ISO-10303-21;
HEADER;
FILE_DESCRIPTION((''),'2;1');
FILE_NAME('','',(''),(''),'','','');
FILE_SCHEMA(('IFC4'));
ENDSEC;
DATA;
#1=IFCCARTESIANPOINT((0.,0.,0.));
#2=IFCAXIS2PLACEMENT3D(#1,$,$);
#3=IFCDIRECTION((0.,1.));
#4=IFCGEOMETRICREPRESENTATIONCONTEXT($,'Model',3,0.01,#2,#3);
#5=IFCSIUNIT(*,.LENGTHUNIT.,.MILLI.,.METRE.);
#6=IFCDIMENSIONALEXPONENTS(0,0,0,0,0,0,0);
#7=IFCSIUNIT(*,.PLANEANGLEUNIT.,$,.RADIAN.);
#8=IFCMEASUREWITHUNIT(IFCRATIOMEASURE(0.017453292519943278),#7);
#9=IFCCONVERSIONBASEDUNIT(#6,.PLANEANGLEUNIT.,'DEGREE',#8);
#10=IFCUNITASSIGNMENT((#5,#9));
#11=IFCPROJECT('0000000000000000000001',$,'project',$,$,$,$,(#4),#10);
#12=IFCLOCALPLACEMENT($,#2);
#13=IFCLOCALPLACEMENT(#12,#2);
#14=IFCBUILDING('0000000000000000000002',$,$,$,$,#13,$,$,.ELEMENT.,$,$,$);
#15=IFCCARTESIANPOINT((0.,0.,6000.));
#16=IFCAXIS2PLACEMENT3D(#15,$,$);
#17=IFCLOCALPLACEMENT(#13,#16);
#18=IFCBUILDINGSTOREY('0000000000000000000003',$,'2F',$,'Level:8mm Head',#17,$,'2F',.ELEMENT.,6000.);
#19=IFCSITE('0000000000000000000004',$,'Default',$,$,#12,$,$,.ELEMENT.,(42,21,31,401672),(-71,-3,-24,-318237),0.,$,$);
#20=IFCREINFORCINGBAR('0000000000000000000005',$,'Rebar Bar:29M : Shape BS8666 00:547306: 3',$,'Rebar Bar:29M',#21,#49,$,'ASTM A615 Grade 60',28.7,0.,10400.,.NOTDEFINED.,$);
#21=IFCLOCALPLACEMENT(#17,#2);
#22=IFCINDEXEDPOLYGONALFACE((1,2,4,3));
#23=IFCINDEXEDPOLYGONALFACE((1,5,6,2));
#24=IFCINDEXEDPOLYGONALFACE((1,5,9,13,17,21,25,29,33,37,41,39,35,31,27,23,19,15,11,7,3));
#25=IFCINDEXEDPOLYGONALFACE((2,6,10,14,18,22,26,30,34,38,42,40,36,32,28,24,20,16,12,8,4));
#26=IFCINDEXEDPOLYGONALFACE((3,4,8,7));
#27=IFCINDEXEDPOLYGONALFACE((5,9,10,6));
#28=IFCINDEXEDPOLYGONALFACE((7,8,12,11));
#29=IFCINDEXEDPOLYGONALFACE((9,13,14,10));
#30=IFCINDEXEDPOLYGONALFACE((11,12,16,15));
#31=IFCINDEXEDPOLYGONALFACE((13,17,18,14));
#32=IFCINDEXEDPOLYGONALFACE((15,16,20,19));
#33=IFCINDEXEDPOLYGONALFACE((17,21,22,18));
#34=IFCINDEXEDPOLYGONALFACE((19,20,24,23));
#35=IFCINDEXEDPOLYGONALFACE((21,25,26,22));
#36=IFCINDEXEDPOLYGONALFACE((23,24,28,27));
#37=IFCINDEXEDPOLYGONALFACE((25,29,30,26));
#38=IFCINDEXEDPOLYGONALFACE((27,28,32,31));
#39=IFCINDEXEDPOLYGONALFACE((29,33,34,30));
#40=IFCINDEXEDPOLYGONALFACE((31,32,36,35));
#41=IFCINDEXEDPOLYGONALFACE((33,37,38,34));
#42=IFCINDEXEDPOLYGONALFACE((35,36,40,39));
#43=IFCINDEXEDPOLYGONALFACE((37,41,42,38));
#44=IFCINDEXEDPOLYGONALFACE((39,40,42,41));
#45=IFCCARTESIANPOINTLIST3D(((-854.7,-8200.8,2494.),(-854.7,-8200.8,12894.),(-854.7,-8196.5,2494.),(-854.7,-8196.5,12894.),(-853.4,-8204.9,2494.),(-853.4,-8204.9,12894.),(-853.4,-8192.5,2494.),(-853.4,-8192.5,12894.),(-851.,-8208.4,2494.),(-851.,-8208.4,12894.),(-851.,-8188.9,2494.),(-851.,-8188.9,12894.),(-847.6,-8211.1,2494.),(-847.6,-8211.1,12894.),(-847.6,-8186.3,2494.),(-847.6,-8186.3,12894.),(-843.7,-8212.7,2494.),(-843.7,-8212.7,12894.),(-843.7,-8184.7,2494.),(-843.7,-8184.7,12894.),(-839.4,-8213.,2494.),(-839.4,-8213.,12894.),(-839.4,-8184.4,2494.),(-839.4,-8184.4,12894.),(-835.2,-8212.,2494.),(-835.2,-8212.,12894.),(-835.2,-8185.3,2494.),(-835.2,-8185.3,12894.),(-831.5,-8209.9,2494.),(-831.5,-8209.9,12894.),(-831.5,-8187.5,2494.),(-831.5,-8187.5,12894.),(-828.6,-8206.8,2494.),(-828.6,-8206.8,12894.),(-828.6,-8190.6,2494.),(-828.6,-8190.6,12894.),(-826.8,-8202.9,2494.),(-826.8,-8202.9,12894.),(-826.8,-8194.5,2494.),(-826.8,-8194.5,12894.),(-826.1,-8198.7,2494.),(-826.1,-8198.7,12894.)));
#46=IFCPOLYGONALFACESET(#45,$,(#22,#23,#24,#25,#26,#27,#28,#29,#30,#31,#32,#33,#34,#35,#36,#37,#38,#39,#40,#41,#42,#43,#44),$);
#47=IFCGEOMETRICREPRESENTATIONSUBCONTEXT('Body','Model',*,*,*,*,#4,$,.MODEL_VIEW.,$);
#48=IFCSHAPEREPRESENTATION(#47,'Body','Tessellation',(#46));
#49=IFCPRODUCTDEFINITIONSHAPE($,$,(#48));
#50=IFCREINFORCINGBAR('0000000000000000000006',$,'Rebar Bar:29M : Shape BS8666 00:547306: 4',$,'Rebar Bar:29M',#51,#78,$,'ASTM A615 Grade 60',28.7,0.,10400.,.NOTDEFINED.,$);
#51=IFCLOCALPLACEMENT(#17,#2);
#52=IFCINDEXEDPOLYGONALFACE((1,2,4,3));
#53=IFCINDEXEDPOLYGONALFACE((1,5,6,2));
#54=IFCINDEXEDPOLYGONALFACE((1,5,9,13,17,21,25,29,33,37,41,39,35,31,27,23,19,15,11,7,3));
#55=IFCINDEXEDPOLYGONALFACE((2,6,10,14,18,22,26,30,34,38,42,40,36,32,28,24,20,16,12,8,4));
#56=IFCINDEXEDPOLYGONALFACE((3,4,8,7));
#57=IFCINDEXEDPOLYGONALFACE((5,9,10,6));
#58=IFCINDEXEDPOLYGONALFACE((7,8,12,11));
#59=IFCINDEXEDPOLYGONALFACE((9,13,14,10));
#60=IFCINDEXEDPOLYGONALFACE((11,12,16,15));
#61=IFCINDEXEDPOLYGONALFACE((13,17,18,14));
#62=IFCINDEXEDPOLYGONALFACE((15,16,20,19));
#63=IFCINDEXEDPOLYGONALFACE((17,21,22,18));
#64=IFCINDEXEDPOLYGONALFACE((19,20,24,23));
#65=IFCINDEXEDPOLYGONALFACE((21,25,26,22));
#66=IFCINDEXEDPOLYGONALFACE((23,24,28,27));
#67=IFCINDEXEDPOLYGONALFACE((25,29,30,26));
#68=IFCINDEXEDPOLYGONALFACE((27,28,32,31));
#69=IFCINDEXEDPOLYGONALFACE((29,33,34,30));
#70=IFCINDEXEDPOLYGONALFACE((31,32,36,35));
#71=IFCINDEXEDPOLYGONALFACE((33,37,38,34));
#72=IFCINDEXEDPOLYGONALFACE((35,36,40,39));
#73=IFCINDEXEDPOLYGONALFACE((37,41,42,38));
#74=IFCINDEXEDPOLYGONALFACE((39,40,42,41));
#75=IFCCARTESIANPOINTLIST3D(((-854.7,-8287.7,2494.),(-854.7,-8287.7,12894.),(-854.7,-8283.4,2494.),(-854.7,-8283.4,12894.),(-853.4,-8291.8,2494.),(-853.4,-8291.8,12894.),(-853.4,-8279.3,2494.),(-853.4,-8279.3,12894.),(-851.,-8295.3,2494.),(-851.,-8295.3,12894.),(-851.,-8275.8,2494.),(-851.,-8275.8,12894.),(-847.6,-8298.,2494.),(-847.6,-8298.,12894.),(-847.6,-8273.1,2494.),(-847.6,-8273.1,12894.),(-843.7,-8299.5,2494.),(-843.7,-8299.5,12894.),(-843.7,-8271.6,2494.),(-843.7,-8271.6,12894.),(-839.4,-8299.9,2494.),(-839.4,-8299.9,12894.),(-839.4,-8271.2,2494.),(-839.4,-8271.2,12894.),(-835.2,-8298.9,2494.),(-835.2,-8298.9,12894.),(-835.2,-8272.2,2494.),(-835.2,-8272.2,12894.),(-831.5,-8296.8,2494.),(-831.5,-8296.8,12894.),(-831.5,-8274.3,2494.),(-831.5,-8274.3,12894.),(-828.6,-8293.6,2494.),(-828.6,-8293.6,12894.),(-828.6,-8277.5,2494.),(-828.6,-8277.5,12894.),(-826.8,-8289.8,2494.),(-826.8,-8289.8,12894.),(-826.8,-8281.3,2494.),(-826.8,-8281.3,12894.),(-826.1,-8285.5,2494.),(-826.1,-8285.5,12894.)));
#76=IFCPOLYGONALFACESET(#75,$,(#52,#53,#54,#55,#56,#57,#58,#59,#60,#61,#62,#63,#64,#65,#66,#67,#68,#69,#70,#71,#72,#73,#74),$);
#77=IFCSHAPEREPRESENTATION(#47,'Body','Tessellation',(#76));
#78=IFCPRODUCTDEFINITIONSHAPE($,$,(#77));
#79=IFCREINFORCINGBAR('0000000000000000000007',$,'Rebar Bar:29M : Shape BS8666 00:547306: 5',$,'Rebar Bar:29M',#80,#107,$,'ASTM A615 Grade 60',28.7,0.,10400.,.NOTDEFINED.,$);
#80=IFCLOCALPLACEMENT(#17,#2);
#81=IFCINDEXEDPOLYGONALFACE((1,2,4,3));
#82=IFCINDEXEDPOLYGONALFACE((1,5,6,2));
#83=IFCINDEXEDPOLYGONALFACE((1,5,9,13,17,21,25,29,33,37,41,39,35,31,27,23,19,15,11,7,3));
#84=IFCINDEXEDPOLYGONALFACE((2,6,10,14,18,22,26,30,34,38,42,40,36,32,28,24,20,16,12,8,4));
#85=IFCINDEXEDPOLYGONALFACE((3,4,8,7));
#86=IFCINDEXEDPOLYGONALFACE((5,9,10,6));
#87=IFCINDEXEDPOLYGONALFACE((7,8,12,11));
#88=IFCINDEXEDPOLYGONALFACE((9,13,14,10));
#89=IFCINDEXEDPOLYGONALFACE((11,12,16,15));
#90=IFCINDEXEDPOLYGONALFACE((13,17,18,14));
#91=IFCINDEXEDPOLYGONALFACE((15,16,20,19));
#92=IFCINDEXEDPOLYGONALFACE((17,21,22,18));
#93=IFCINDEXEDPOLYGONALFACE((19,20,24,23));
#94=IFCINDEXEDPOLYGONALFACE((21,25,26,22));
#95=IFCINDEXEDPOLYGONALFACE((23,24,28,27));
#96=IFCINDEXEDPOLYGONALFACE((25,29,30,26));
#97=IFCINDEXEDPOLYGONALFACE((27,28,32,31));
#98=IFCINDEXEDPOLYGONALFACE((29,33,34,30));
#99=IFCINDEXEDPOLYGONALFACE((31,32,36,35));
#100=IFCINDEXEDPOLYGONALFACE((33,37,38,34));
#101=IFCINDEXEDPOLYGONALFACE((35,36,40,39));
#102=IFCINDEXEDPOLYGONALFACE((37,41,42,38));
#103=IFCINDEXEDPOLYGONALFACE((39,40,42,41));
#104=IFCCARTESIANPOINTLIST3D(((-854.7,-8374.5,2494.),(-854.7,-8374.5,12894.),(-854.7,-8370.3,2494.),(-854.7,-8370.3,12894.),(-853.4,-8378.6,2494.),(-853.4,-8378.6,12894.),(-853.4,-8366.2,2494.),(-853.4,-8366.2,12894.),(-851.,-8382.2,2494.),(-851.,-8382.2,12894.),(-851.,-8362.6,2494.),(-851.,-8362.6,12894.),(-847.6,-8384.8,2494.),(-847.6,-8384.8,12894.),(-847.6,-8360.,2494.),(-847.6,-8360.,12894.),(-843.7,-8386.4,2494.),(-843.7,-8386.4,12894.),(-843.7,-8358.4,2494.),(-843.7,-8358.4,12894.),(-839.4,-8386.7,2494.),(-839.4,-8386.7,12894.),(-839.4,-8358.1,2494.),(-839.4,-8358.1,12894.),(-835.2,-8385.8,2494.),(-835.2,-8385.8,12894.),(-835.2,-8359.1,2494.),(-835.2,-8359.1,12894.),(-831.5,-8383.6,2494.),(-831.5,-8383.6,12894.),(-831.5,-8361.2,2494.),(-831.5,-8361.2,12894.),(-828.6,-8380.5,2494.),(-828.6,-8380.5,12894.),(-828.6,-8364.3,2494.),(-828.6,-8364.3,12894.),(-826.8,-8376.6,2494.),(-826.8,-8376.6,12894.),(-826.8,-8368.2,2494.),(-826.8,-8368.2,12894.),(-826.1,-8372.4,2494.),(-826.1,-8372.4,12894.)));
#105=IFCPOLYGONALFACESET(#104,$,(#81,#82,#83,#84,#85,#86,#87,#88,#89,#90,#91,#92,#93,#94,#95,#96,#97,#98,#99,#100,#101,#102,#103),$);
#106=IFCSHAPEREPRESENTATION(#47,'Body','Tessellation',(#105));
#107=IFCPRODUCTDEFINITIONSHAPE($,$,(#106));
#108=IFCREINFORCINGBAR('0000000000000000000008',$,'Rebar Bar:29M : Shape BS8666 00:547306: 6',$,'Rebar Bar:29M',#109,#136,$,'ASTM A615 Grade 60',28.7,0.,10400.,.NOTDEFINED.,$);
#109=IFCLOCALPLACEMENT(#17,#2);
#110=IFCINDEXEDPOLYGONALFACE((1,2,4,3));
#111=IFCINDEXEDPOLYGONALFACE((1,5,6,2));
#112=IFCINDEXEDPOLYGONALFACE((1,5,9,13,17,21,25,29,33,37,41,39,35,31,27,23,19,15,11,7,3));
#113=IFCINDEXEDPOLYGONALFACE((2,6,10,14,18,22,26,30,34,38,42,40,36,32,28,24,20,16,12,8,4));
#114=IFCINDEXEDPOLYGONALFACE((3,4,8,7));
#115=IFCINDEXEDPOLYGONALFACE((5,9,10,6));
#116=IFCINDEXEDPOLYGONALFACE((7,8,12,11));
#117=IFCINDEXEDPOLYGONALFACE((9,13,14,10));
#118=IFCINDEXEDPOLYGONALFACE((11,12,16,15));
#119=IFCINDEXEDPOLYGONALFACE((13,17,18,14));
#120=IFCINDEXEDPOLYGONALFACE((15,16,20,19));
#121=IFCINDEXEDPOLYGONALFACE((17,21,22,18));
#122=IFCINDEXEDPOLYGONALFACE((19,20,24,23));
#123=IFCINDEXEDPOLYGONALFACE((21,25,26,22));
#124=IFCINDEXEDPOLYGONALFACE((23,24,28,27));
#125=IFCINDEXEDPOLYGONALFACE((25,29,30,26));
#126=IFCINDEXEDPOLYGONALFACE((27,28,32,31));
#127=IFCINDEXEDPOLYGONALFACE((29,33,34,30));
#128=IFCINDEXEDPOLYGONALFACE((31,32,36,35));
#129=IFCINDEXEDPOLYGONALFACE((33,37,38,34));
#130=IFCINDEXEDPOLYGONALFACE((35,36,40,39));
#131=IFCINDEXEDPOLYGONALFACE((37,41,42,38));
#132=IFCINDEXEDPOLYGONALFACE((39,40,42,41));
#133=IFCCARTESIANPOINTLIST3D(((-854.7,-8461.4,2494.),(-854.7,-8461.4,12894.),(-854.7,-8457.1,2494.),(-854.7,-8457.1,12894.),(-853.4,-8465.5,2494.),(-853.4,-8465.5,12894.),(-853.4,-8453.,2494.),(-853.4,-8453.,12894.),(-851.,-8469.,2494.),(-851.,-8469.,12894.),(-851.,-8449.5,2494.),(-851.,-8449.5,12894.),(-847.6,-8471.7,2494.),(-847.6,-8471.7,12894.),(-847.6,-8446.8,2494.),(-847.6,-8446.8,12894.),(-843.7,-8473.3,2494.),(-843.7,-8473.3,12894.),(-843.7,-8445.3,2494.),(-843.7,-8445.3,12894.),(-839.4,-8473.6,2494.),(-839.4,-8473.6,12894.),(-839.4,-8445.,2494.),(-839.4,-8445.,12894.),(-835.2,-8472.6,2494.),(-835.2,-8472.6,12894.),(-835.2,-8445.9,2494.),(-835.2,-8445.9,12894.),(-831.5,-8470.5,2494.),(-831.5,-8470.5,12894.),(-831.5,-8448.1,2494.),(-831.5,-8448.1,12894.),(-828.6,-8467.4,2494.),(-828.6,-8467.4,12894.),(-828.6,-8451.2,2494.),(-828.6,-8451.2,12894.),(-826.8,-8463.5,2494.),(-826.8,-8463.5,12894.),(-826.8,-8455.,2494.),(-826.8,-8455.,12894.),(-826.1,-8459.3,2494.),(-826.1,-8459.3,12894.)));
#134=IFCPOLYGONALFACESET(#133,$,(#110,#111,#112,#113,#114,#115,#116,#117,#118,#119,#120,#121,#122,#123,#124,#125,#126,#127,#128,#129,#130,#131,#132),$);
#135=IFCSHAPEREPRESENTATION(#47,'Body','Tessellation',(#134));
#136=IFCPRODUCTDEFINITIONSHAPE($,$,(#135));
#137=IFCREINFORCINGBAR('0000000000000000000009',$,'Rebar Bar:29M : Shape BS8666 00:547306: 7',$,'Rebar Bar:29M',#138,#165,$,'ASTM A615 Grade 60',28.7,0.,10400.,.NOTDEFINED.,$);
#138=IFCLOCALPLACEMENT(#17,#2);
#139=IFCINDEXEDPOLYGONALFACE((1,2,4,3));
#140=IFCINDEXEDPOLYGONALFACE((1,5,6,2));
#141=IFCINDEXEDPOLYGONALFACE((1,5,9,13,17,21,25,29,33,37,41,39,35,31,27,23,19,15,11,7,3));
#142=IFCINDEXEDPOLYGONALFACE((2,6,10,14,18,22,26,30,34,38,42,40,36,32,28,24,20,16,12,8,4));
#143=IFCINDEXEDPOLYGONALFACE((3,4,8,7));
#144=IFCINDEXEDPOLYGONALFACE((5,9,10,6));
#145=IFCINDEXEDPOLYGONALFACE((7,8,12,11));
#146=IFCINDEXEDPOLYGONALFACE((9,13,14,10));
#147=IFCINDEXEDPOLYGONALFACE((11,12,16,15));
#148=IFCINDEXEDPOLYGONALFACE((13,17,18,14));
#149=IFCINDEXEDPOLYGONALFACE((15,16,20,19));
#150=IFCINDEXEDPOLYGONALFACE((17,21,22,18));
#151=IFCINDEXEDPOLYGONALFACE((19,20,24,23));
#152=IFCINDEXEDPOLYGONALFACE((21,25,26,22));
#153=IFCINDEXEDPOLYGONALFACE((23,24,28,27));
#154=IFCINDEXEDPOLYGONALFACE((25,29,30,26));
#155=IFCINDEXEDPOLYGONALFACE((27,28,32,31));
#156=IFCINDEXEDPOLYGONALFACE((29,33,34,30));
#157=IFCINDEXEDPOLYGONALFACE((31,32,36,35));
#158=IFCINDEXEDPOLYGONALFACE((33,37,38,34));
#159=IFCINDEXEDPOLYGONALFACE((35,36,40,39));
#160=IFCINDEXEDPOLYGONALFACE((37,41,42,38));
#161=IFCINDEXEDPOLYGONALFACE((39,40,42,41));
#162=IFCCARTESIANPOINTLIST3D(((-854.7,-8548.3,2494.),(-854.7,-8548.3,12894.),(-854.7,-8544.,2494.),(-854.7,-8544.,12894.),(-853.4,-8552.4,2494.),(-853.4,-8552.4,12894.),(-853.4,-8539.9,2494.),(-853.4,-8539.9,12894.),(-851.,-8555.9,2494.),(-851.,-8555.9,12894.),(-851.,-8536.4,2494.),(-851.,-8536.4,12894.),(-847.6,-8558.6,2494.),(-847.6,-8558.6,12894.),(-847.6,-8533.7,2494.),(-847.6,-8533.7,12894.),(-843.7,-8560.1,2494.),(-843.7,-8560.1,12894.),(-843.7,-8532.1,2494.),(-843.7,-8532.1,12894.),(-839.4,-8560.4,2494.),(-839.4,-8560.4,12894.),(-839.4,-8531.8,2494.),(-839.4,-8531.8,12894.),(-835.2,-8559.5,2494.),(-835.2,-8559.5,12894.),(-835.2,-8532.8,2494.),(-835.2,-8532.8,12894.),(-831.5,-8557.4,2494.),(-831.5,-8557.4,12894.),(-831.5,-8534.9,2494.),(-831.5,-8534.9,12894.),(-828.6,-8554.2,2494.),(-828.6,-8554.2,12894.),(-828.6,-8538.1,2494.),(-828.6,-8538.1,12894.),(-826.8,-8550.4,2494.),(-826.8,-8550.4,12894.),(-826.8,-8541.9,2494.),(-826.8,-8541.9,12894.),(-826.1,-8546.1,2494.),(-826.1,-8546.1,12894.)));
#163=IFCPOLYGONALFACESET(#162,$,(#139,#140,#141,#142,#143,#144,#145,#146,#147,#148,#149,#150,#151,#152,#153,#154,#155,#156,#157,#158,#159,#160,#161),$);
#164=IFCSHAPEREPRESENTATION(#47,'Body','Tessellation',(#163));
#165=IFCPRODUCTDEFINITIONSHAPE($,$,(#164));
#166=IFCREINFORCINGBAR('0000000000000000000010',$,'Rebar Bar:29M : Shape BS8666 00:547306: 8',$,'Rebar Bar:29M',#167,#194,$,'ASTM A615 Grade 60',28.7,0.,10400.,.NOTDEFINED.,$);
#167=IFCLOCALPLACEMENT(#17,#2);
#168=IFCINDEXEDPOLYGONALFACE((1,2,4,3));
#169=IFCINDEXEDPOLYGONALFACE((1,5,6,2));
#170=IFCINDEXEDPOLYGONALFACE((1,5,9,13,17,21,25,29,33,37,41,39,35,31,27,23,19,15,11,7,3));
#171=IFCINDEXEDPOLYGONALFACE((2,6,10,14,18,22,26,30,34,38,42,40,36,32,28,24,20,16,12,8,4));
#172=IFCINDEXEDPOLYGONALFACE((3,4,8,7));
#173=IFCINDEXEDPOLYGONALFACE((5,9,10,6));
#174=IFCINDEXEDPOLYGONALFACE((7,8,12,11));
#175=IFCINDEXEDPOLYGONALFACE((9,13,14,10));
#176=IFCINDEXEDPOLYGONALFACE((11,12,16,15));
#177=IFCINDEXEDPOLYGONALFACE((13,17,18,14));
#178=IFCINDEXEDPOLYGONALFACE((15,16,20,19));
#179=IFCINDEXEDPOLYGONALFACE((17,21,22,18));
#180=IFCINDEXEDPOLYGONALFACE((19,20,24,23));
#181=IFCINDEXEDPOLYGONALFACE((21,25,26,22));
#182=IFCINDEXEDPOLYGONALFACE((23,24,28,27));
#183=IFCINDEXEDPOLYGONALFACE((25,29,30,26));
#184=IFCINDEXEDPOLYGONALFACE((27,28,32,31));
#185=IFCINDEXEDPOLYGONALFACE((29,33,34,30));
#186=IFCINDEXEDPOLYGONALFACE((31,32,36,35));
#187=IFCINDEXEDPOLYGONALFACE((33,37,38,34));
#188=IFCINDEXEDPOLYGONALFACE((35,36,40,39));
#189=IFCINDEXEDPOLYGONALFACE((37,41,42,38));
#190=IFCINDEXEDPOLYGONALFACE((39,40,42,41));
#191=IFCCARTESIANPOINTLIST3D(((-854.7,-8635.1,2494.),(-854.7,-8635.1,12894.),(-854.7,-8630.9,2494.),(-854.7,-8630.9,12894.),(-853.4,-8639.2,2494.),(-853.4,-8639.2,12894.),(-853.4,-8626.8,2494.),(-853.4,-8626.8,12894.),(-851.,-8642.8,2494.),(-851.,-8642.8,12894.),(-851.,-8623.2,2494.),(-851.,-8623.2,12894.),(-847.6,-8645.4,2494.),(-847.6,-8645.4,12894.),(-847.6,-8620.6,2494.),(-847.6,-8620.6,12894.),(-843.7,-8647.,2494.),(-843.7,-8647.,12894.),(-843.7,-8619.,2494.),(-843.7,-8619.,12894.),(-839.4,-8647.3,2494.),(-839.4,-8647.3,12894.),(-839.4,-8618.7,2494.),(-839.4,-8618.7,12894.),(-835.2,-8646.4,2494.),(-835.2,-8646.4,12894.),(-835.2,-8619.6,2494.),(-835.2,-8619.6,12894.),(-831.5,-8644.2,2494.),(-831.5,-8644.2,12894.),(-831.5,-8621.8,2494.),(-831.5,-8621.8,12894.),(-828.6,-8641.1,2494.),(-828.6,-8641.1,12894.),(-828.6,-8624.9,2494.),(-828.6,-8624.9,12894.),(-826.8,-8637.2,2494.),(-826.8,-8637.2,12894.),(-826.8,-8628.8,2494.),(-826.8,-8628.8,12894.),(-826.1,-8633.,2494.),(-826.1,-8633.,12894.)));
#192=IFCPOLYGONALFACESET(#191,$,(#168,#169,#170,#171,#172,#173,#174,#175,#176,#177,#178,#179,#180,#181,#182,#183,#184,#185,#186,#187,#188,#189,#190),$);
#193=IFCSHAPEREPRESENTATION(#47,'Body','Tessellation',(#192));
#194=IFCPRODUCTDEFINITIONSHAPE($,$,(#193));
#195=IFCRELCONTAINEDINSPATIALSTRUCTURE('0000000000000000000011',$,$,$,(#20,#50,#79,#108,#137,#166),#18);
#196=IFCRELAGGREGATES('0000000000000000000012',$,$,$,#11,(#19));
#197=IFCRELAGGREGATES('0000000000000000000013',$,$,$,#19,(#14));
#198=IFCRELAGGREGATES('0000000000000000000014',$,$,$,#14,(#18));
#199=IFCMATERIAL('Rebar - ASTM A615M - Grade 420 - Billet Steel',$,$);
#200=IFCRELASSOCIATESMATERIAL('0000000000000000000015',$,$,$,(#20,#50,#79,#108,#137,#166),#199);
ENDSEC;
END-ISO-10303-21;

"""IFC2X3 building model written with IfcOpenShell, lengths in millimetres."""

from ifc_helpers import new_model, entity, si_unit, converted_unit, direction, frame, origin, place, context, subcontext, project, spatial, material, element, save


model = new_model("IFC2X3")

# Units and contexts
model_context = context("Model", 3, precision=0.01, world=origin(), true_north=direction((0.0, 1.0)))
body_context = subcontext(model_context, "Body", "Model", "MODEL_VIEW")
ifc_project = project(units=[si_unit("LENGTHUNIT", "METRE", prefix="MILLI"), converted_unit("PLANEANGLEUNIT", "DEGREE", entity("IfcRatioMeasure", 0.017453292519943278), si_unit("PLANEANGLEUNIT", "RADIAN"), dimensions=[0, 0, 0, 0, 0, 0, 0])], contexts=[model_context])

# Site, building, storey
site_placement = place(None, origin())
site = spatial("IfcSite", under=ifc_project, at=site_placement, Name="Default", CompositionType="ELEMENT", RefLatitude=(42, 21, 31, 401672), RefLongitude=(-71, -3, -24, -318237), RefElevation=0.0)
building_placement = place(site_placement, origin())
building = spatial("IfcBuilding", under=site, at=building_placement, CompositionType="ELEMENT")
storey_placement = place(building_placement, frame((0.0, 0.0, 6000.0)))
storey = spatial("IfcBuildingStorey", under=building, at=storey_placement, Name="2F", ObjectType="Level:8mm Head", LongName="2F", CompositionType="ELEMENT", Elevation=6000.0)

# Reinforcing bars
ifc_material = material(Name="Rebar - ASTM A615M - Grade 420 - Billet Steel")
reinforcing_bar_1_placement = place(storey_placement, origin())
element("IfcReinforcingBar", 1, at=reinforcing_bar_1_placement, inside=storey, material=ifc_material, Name="Rebar Bar:29M : Shape BS8666 00:547306: 3", SteelGrade="ASTM A615 Grade 60", ObjectType="Rebar Bar:29M", BarLength=10400.0, BarRole="NOTDEFINED", CrossSectionArea=0.0, NominalDiameter=28.7, context=body_context, shape_type="AdvancedSweptSolid", body=[
    entity("IfcSweptDiskSolid", entity("IfcCompositeCurve", [entity("IfcCompositeCurveSegment", "CONTINUOUS", True, entity("IfcPolyline", [entity("IfcCartesianPoint", [-840.5, -8198.7, 2494.0]), entity("IfcCartesianPoint", [-840.5, -8198.7, 12894.0])]))], False), 14.3, None, 0.0, 1.0),
])
reinforcing_bar_2_placement = place(storey_placement, origin())
element("IfcReinforcingBar", 2, at=reinforcing_bar_2_placement, inside=storey, material=ifc_material, Name="Rebar Bar:29M : Shape BS8666 00:547306: 4", SteelGrade="ASTM A615 Grade 60", ObjectType="Rebar Bar:29M", BarLength=10400.0, BarRole="NOTDEFINED", CrossSectionArea=0.0, NominalDiameter=28.7, context=body_context, shape_type="AdvancedSweptSolid", body=[
    entity("IfcSweptDiskSolid", entity("IfcCompositeCurve", [entity("IfcCompositeCurveSegment", "CONTINUOUS", True, entity("IfcPolyline", [entity("IfcCartesianPoint", [-840.5, -8285.5, 2494.0]), entity("IfcCartesianPoint", [-840.5, -8285.5, 12894.0])]))], False), 14.3, None, 0.0, 1.0),
])
reinforcing_bar_3_placement = place(storey_placement, origin())
element("IfcReinforcingBar", 3, at=reinforcing_bar_3_placement, inside=storey, material=ifc_material, Name="Rebar Bar:29M : Shape BS8666 00:547306: 5", SteelGrade="ASTM A615 Grade 60", ObjectType="Rebar Bar:29M", BarLength=10400.0, BarRole="NOTDEFINED", CrossSectionArea=0.0, NominalDiameter=28.7, context=body_context, shape_type="AdvancedSweptSolid", body=[
    entity("IfcSweptDiskSolid", entity("IfcCompositeCurve", [entity("IfcCompositeCurveSegment", "CONTINUOUS", True, entity("IfcPolyline", [entity("IfcCartesianPoint", [-840.5, -8372.4, 2494.0]), entity("IfcCartesianPoint", [-840.5, -8372.4, 12894.0])]))], False), 14.3, None, 0.0, 1.0),
])
reinforcing_bar_4_placement = place(storey_placement, origin())
element("IfcReinforcingBar", 4, at=reinforcing_bar_4_placement, inside=storey, material=ifc_material, Name="Rebar Bar:29M : Shape BS8666 00:547306: 6", SteelGrade="ASTM A615 Grade 60", ObjectType="Rebar Bar:29M", BarLength=10400.0, BarRole="NOTDEFINED", CrossSectionArea=0.0, NominalDiameter=28.7, context=body_context, shape_type="AdvancedSweptSolid", body=[
    entity("IfcSweptDiskSolid", entity("IfcCompositeCurve", [entity("IfcCompositeCurveSegment", "CONTINUOUS", True, entity("IfcPolyline", [entity("IfcCartesianPoint", [-840.5, -8459.3, 2494.0]), entity("IfcCartesianPoint", [-840.5, -8459.3, 12894.0])]))], False), 14.3, None, 0.0, 1.0),
])
reinforcing_bar_5_placement = place(storey_placement, origin())
element("IfcReinforcingBar", 5, at=reinforcing_bar_5_placement, inside=storey, material=ifc_material, Name="Rebar Bar:29M : Shape BS8666 00:547306: 7", SteelGrade="ASTM A615 Grade 60", ObjectType="Rebar Bar:29M", BarLength=10400.0, BarRole="NOTDEFINED", CrossSectionArea=0.0, NominalDiameter=28.7, context=body_context, shape_type="AdvancedSweptSolid", body=[
    entity("IfcSweptDiskSolid", entity("IfcCompositeCurve", [entity("IfcCompositeCurveSegment", "CONTINUOUS", True, entity("IfcPolyline", [entity("IfcCartesianPoint", [-840.5, -8546.1, 2494.0]), entity("IfcCartesianPoint", [-840.5, -8546.1, 12894.0])]))], False), 14.3, None, 0.0, 1.0),
])
reinforcing_bar_6_placement = place(storey_placement, origin())
element("IfcReinforcingBar", 6, at=reinforcing_bar_6_placement, inside=storey, material=ifc_material, Name="Rebar Bar:29M : Shape BS8666 00:547306: 8", SteelGrade="ASTM A615 Grade 60", ObjectType="Rebar Bar:29M", BarLength=10400.0, BarRole="NOTDEFINED", CrossSectionArea=0.0, NominalDiameter=28.7, context=body_context, shape_type="AdvancedSweptSolid", body=[
    entity("IfcSweptDiskSolid", entity("IfcCompositeCurve", [entity("IfcCompositeCurveSegment", "CONTINUOUS", True, entity("IfcPolyline", [entity("IfcCartesianPoint", [-840.5, -8633.0, 2494.0]), entity("IfcCartesianPoint", [-840.5, -8633.0, 12894.0])]))], False), 14.3, None, 0.0, 1.0),
])

save(model, "model.ifc")
